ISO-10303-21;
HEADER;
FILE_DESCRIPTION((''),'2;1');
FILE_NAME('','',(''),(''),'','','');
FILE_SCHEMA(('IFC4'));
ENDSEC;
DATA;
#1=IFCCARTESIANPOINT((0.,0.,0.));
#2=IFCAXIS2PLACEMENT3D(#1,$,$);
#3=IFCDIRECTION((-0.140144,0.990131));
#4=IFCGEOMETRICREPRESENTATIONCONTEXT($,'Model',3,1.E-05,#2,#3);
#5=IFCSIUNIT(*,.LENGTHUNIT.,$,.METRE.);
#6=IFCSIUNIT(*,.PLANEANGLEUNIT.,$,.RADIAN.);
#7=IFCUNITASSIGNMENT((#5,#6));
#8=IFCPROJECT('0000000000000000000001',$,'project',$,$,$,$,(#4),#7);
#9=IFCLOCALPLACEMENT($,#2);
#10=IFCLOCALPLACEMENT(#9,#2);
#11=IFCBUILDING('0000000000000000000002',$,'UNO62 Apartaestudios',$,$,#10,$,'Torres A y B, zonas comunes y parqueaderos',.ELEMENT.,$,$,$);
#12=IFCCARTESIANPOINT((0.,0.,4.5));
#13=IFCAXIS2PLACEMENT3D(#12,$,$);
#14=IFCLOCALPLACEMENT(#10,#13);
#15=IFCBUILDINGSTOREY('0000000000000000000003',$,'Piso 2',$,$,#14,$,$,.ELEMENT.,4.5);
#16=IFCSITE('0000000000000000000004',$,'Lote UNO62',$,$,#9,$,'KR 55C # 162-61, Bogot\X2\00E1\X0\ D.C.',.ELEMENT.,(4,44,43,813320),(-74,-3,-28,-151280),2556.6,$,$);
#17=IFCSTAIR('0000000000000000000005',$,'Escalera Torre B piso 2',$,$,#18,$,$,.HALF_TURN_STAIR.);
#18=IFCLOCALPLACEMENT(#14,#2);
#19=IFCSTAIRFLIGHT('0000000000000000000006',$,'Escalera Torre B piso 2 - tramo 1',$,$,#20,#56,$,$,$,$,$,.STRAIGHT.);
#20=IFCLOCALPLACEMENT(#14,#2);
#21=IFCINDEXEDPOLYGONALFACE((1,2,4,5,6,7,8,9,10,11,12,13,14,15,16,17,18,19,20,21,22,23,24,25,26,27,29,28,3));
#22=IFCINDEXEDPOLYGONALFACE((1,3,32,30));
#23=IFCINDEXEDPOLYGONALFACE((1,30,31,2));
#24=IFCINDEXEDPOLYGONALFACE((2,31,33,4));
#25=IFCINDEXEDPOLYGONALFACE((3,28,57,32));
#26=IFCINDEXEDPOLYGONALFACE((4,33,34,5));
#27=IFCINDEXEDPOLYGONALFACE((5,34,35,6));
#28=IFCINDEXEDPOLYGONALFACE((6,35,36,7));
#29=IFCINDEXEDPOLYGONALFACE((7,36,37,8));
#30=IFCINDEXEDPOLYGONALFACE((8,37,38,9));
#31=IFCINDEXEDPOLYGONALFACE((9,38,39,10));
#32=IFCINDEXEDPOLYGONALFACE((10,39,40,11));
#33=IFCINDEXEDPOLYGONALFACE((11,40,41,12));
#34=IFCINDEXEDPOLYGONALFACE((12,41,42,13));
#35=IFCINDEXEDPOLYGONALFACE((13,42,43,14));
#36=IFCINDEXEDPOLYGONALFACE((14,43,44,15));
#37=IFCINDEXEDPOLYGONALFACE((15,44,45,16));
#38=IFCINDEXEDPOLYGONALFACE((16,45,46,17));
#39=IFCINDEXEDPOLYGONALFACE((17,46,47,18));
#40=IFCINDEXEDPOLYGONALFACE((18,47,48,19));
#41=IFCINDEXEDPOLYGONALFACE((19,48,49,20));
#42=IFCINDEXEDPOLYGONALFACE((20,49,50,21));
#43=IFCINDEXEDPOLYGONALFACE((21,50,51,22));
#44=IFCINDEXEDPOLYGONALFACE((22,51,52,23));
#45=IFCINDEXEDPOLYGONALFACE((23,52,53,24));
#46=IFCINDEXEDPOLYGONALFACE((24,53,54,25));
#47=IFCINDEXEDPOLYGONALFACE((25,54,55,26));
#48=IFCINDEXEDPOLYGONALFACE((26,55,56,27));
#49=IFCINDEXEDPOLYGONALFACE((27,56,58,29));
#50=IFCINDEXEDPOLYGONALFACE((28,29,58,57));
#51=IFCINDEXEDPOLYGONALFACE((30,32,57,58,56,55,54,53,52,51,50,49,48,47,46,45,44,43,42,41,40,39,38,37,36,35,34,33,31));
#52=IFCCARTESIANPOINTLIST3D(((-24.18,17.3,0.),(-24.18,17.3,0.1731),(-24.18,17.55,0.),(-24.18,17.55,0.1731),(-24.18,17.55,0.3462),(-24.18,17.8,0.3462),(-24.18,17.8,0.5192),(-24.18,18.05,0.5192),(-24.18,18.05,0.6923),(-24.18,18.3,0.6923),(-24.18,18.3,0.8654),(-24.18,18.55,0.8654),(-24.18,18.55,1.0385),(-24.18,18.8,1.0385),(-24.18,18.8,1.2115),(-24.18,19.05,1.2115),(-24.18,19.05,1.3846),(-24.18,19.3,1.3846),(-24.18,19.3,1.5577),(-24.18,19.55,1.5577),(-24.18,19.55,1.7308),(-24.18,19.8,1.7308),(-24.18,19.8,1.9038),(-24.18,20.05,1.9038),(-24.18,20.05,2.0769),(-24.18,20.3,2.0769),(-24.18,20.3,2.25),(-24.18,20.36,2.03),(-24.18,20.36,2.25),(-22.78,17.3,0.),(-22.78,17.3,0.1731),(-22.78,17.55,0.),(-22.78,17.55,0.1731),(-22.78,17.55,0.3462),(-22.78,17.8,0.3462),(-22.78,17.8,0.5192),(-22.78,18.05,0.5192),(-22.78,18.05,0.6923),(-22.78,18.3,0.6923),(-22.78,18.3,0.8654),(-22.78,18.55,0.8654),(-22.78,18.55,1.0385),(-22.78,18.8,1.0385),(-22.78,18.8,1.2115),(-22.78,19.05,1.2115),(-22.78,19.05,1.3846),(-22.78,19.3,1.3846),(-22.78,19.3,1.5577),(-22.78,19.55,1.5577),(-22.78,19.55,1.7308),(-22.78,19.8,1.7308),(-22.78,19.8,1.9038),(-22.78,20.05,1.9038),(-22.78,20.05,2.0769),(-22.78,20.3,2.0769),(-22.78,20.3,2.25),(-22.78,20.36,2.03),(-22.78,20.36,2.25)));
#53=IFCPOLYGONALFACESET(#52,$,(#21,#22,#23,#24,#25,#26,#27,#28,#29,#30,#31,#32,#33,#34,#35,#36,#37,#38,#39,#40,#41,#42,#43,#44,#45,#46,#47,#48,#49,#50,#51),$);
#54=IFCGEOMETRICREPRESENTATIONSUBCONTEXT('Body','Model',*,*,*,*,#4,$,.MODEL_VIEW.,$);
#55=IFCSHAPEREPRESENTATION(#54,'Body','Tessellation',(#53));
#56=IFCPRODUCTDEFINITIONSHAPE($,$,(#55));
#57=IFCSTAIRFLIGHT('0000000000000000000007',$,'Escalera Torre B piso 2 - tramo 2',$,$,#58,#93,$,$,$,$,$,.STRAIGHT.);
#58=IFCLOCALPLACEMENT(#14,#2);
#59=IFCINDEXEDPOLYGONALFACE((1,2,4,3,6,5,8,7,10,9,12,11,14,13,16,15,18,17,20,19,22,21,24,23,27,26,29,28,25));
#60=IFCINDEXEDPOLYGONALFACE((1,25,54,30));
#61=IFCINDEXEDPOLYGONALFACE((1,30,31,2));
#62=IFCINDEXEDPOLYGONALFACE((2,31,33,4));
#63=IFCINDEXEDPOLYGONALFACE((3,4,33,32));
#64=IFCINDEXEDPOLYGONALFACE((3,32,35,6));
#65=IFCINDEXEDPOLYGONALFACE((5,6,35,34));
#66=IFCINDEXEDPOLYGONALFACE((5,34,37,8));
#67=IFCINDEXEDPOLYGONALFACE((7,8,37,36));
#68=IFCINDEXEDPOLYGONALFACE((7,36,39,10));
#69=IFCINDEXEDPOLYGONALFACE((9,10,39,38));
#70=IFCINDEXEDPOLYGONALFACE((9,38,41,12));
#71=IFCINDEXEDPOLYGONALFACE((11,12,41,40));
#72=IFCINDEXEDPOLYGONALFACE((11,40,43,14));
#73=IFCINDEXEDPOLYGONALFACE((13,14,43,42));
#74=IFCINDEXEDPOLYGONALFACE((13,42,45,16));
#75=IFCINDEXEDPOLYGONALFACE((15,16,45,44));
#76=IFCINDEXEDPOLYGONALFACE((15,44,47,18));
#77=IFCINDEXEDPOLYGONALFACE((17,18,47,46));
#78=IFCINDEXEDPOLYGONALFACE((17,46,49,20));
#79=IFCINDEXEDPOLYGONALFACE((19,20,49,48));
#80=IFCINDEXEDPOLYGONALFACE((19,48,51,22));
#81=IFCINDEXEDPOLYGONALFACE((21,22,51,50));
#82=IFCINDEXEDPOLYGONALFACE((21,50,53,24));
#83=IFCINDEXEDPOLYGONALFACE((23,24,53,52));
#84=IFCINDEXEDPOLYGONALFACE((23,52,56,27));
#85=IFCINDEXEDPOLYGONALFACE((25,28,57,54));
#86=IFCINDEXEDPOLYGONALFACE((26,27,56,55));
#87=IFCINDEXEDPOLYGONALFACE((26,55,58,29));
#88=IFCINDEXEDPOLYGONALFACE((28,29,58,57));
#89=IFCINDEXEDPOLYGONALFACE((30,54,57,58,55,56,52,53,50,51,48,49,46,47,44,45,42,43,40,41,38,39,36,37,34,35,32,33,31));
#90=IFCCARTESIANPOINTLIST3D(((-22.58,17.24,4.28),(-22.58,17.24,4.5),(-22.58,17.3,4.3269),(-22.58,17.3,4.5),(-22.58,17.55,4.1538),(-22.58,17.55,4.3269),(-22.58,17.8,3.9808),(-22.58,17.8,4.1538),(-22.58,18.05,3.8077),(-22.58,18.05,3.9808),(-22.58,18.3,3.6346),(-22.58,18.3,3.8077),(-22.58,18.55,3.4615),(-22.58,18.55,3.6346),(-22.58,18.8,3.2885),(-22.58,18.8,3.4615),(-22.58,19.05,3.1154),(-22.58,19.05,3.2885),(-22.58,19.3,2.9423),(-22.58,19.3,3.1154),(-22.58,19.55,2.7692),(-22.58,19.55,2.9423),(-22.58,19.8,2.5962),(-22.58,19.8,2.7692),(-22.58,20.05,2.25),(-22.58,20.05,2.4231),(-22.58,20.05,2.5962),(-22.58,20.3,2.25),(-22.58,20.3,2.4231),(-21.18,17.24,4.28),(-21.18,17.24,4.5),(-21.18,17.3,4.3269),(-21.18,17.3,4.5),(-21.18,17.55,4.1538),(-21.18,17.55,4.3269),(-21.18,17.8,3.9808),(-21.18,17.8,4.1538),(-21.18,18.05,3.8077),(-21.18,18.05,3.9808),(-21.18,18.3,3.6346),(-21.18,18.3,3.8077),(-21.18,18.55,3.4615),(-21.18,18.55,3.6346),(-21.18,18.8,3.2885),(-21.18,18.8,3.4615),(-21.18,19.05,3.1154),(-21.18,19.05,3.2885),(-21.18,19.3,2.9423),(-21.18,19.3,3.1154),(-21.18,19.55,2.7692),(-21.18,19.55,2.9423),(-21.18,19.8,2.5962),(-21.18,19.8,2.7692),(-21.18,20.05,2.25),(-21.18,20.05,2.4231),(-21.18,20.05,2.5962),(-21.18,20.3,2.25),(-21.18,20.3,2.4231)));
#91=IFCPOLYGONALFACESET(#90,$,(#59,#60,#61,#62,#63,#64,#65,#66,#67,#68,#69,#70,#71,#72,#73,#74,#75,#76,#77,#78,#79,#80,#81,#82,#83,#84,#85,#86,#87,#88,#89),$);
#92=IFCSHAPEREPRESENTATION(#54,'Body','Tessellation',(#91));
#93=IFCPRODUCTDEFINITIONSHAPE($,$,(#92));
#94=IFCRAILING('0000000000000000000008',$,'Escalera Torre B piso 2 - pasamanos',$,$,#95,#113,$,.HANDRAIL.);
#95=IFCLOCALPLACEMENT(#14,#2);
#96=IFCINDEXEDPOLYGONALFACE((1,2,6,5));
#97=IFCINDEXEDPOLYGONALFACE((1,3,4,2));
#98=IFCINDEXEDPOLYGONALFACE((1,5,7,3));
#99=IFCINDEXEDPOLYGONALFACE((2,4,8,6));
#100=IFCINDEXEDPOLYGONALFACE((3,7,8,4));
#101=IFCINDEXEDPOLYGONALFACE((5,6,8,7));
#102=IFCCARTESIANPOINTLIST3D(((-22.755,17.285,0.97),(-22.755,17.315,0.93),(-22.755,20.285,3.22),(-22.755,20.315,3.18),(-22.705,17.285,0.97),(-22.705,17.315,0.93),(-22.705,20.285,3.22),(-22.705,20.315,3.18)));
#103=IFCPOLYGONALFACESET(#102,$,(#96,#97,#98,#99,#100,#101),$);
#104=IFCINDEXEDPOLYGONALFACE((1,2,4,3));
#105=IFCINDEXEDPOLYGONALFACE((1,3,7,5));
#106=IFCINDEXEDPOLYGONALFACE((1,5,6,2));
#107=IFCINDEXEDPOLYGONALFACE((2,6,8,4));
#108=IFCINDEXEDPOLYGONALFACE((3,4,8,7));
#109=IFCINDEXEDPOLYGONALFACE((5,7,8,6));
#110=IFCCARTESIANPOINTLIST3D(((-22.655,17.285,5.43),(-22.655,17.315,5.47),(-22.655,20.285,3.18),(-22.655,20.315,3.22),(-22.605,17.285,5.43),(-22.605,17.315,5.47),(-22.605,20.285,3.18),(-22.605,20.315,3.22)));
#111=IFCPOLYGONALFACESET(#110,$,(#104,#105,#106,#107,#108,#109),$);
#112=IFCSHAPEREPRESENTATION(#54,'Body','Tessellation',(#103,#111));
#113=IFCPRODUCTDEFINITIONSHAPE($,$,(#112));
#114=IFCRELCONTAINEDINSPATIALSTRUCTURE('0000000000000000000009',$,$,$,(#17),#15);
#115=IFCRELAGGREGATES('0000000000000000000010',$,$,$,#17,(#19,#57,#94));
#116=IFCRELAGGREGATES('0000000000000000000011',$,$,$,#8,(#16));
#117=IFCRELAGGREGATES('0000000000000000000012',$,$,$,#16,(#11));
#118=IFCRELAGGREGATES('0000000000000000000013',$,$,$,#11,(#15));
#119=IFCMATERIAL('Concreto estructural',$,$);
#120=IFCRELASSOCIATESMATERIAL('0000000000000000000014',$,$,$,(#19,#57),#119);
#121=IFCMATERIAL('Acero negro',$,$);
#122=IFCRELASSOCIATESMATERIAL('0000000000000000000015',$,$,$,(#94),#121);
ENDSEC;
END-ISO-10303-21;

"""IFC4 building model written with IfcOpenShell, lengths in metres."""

from ifc_helpers import new_model, si_unit, direction, frame, origin, origin_2d, place, context, subcontext, project, spatial, polyline, rectangle, outline, extrude, material, element, aggregate, save


model = new_model("IFC4")

# Units and contexts
model_context = context("Model", 3, precision=1e-05, world=origin(), true_north=direction((-0.140144, 0.990131)))
body_context = subcontext(model_context, "Body", "Model", "MODEL_VIEW")
ifc_project = project(units=[si_unit("LENGTHUNIT", "METRE"), si_unit("PLANEANGLEUNIT", "RADIAN")], contexts=[model_context])

# Site, building, storey
site_placement = place(None, origin())
site = spatial("IfcSite", under=ifc_project, at=site_placement, Name="Lote UNO62", LongName="KR 55C # 162-61, Bogotá D.C.", CompositionType="ELEMENT", RefLatitude=(4, 44, 43, 813320), RefLongitude=(-74, -3, -28, -151280), RefElevation=2556.6)
building_placement = place(site_placement, origin())
building = spatial("IfcBuilding", under=site, at=building_placement, Name="UNO62 Apartaestudios", LongName="Torres A y B, zonas comunes y parqueaderos", CompositionType="ELEMENT")
storey_placement = place(building_placement, frame((0.0, 0.0, 4.5)))
storey = spatial("IfcBuildingStorey", under=building, at=storey_placement, Name="Piso 2", CompositionType="ELEMENT", Elevation=4.5)

# Stair
stair_placement = place(storey_placement, origin())
stair = element("IfcStair", 1, at=stair_placement, inside=storey, Name="Escalera Torre B piso 2", PredefinedType="HALF_TURN_STAIR")
ifc_material_1 = material(Name="Concreto estructural")

# Stair flights
stair_flight_1_placement = place(storey_placement, origin())
stair_flight_1 = element("IfcStairFlight", 2, at=stair_flight_1_placement, material=ifc_material_1, Name="Escalera Torre B piso 2 - tramo 1", PredefinedType="STRAIGHT", context=body_context, shape_type="SweptSolid", body=[
    extrude(outline(polyline([(0.0, 0.0), (0.0, 0.1731), (0.25, 0.1731), (0.25, 0.3462), (0.5, 0.3462), (0.5, 0.5192), (0.75, 0.5192), (0.75, 0.6923), (1.0, 0.6923), (1.0, 0.8654), (1.25, 0.8654), (1.25, 1.0385), (1.5, 1.0385), (1.5, 1.2115), (1.75, 1.2115), (1.75, 1.3846), (2.0, 1.3846), (2.0, 1.5577), (2.25, 1.5577), (2.25, 1.7308), (2.5, 1.7308), (2.5, 1.9038), (2.75, 1.9038), (2.75, 2.0769), (3.0, 2.0769), (3.0, 2.25), (3.06, 2.25), (3.06, 2.03), (0.25, 0.0), (0.0, 0.0)])), frame((-24.18, 17.3, 0.0), z_axis=(1.0, 0.0, 0.0), x_axis=(0.0, 1.0, 0.0)), (0.0, 0.0, 1.0), 1.4),
])
stair_flight_2_placement = place(storey_placement, origin())
stair_flight_2 = element("IfcStairFlight", 3, at=stair_flight_2_placement, material=ifc_material_1, Name="Escalera Torre B piso 2 - tramo 2", PredefinedType="STRAIGHT", context=body_context, shape_type="SweptSolid", body=[
    extrude(outline(polyline([(0.0, 0.0), (0.0, 0.1731), (0.25, 0.1731), (0.25, 0.3462), (0.5, 0.3462), (0.5, 0.5192), (0.75, 0.5192), (0.75, 0.6923), (1.0, 0.6923), (1.0, 0.8654), (1.25, 0.8654), (1.25, 1.0385), (1.5, 1.0385), (1.5, 1.2115), (1.75, 1.2115), (1.75, 1.3846), (2.0, 1.3846), (2.0, 1.5577), (2.25, 1.5577), (2.25, 1.7308), (2.5, 1.7308), (2.5, 1.9038), (2.75, 1.9038), (2.75, 2.0769), (3.0, 2.0769), (3.0, 2.25), (3.06, 2.25), (3.06, 2.03), (0.25, 0.0), (0.0, 0.0)])), frame((-21.18, 20.3, 2.25), z_axis=(-1.0, 0.0, 0.0), x_axis=(0.0, -1.0, 0.0)), (0.0, 0.0, 1.0), 1.4),
])

# Railing
ifc_material_2 = material(Name="Acero negro")
railing_1_placement = place(storey_placement, origin())
railing_1 = element("IfcRailing", 4, at=railing_1_placement, material=ifc_material_2, Name="Escalera Torre B piso 2 - pasamanos", PredefinedType="HANDRAIL", context=body_context, shape_type="SweptSolid", body=[
    extrude(rectangle(XDim=0.05, YDim=0.05, at=origin_2d()), frame((-22.73, 17.3, 0.95), z_axis=(0.0, 0.8, 0.6), x_axis=(1.0, 0.0, 0.0)), (0.0, 0.0, 1.0), 3.75),
    extrude(rectangle(XDim=0.05, YDim=0.05, at=origin_2d()), frame((-22.63, 20.3, 3.2), z_axis=(0.0, -0.8, 0.6), x_axis=(-1.0, 0.0, 0.0)), (0.0, 0.0, 1.0), 3.75),
])
aggregate(stair, [stair_flight_1, stair_flight_2, railing_1])

save(model, "model.ifc")
